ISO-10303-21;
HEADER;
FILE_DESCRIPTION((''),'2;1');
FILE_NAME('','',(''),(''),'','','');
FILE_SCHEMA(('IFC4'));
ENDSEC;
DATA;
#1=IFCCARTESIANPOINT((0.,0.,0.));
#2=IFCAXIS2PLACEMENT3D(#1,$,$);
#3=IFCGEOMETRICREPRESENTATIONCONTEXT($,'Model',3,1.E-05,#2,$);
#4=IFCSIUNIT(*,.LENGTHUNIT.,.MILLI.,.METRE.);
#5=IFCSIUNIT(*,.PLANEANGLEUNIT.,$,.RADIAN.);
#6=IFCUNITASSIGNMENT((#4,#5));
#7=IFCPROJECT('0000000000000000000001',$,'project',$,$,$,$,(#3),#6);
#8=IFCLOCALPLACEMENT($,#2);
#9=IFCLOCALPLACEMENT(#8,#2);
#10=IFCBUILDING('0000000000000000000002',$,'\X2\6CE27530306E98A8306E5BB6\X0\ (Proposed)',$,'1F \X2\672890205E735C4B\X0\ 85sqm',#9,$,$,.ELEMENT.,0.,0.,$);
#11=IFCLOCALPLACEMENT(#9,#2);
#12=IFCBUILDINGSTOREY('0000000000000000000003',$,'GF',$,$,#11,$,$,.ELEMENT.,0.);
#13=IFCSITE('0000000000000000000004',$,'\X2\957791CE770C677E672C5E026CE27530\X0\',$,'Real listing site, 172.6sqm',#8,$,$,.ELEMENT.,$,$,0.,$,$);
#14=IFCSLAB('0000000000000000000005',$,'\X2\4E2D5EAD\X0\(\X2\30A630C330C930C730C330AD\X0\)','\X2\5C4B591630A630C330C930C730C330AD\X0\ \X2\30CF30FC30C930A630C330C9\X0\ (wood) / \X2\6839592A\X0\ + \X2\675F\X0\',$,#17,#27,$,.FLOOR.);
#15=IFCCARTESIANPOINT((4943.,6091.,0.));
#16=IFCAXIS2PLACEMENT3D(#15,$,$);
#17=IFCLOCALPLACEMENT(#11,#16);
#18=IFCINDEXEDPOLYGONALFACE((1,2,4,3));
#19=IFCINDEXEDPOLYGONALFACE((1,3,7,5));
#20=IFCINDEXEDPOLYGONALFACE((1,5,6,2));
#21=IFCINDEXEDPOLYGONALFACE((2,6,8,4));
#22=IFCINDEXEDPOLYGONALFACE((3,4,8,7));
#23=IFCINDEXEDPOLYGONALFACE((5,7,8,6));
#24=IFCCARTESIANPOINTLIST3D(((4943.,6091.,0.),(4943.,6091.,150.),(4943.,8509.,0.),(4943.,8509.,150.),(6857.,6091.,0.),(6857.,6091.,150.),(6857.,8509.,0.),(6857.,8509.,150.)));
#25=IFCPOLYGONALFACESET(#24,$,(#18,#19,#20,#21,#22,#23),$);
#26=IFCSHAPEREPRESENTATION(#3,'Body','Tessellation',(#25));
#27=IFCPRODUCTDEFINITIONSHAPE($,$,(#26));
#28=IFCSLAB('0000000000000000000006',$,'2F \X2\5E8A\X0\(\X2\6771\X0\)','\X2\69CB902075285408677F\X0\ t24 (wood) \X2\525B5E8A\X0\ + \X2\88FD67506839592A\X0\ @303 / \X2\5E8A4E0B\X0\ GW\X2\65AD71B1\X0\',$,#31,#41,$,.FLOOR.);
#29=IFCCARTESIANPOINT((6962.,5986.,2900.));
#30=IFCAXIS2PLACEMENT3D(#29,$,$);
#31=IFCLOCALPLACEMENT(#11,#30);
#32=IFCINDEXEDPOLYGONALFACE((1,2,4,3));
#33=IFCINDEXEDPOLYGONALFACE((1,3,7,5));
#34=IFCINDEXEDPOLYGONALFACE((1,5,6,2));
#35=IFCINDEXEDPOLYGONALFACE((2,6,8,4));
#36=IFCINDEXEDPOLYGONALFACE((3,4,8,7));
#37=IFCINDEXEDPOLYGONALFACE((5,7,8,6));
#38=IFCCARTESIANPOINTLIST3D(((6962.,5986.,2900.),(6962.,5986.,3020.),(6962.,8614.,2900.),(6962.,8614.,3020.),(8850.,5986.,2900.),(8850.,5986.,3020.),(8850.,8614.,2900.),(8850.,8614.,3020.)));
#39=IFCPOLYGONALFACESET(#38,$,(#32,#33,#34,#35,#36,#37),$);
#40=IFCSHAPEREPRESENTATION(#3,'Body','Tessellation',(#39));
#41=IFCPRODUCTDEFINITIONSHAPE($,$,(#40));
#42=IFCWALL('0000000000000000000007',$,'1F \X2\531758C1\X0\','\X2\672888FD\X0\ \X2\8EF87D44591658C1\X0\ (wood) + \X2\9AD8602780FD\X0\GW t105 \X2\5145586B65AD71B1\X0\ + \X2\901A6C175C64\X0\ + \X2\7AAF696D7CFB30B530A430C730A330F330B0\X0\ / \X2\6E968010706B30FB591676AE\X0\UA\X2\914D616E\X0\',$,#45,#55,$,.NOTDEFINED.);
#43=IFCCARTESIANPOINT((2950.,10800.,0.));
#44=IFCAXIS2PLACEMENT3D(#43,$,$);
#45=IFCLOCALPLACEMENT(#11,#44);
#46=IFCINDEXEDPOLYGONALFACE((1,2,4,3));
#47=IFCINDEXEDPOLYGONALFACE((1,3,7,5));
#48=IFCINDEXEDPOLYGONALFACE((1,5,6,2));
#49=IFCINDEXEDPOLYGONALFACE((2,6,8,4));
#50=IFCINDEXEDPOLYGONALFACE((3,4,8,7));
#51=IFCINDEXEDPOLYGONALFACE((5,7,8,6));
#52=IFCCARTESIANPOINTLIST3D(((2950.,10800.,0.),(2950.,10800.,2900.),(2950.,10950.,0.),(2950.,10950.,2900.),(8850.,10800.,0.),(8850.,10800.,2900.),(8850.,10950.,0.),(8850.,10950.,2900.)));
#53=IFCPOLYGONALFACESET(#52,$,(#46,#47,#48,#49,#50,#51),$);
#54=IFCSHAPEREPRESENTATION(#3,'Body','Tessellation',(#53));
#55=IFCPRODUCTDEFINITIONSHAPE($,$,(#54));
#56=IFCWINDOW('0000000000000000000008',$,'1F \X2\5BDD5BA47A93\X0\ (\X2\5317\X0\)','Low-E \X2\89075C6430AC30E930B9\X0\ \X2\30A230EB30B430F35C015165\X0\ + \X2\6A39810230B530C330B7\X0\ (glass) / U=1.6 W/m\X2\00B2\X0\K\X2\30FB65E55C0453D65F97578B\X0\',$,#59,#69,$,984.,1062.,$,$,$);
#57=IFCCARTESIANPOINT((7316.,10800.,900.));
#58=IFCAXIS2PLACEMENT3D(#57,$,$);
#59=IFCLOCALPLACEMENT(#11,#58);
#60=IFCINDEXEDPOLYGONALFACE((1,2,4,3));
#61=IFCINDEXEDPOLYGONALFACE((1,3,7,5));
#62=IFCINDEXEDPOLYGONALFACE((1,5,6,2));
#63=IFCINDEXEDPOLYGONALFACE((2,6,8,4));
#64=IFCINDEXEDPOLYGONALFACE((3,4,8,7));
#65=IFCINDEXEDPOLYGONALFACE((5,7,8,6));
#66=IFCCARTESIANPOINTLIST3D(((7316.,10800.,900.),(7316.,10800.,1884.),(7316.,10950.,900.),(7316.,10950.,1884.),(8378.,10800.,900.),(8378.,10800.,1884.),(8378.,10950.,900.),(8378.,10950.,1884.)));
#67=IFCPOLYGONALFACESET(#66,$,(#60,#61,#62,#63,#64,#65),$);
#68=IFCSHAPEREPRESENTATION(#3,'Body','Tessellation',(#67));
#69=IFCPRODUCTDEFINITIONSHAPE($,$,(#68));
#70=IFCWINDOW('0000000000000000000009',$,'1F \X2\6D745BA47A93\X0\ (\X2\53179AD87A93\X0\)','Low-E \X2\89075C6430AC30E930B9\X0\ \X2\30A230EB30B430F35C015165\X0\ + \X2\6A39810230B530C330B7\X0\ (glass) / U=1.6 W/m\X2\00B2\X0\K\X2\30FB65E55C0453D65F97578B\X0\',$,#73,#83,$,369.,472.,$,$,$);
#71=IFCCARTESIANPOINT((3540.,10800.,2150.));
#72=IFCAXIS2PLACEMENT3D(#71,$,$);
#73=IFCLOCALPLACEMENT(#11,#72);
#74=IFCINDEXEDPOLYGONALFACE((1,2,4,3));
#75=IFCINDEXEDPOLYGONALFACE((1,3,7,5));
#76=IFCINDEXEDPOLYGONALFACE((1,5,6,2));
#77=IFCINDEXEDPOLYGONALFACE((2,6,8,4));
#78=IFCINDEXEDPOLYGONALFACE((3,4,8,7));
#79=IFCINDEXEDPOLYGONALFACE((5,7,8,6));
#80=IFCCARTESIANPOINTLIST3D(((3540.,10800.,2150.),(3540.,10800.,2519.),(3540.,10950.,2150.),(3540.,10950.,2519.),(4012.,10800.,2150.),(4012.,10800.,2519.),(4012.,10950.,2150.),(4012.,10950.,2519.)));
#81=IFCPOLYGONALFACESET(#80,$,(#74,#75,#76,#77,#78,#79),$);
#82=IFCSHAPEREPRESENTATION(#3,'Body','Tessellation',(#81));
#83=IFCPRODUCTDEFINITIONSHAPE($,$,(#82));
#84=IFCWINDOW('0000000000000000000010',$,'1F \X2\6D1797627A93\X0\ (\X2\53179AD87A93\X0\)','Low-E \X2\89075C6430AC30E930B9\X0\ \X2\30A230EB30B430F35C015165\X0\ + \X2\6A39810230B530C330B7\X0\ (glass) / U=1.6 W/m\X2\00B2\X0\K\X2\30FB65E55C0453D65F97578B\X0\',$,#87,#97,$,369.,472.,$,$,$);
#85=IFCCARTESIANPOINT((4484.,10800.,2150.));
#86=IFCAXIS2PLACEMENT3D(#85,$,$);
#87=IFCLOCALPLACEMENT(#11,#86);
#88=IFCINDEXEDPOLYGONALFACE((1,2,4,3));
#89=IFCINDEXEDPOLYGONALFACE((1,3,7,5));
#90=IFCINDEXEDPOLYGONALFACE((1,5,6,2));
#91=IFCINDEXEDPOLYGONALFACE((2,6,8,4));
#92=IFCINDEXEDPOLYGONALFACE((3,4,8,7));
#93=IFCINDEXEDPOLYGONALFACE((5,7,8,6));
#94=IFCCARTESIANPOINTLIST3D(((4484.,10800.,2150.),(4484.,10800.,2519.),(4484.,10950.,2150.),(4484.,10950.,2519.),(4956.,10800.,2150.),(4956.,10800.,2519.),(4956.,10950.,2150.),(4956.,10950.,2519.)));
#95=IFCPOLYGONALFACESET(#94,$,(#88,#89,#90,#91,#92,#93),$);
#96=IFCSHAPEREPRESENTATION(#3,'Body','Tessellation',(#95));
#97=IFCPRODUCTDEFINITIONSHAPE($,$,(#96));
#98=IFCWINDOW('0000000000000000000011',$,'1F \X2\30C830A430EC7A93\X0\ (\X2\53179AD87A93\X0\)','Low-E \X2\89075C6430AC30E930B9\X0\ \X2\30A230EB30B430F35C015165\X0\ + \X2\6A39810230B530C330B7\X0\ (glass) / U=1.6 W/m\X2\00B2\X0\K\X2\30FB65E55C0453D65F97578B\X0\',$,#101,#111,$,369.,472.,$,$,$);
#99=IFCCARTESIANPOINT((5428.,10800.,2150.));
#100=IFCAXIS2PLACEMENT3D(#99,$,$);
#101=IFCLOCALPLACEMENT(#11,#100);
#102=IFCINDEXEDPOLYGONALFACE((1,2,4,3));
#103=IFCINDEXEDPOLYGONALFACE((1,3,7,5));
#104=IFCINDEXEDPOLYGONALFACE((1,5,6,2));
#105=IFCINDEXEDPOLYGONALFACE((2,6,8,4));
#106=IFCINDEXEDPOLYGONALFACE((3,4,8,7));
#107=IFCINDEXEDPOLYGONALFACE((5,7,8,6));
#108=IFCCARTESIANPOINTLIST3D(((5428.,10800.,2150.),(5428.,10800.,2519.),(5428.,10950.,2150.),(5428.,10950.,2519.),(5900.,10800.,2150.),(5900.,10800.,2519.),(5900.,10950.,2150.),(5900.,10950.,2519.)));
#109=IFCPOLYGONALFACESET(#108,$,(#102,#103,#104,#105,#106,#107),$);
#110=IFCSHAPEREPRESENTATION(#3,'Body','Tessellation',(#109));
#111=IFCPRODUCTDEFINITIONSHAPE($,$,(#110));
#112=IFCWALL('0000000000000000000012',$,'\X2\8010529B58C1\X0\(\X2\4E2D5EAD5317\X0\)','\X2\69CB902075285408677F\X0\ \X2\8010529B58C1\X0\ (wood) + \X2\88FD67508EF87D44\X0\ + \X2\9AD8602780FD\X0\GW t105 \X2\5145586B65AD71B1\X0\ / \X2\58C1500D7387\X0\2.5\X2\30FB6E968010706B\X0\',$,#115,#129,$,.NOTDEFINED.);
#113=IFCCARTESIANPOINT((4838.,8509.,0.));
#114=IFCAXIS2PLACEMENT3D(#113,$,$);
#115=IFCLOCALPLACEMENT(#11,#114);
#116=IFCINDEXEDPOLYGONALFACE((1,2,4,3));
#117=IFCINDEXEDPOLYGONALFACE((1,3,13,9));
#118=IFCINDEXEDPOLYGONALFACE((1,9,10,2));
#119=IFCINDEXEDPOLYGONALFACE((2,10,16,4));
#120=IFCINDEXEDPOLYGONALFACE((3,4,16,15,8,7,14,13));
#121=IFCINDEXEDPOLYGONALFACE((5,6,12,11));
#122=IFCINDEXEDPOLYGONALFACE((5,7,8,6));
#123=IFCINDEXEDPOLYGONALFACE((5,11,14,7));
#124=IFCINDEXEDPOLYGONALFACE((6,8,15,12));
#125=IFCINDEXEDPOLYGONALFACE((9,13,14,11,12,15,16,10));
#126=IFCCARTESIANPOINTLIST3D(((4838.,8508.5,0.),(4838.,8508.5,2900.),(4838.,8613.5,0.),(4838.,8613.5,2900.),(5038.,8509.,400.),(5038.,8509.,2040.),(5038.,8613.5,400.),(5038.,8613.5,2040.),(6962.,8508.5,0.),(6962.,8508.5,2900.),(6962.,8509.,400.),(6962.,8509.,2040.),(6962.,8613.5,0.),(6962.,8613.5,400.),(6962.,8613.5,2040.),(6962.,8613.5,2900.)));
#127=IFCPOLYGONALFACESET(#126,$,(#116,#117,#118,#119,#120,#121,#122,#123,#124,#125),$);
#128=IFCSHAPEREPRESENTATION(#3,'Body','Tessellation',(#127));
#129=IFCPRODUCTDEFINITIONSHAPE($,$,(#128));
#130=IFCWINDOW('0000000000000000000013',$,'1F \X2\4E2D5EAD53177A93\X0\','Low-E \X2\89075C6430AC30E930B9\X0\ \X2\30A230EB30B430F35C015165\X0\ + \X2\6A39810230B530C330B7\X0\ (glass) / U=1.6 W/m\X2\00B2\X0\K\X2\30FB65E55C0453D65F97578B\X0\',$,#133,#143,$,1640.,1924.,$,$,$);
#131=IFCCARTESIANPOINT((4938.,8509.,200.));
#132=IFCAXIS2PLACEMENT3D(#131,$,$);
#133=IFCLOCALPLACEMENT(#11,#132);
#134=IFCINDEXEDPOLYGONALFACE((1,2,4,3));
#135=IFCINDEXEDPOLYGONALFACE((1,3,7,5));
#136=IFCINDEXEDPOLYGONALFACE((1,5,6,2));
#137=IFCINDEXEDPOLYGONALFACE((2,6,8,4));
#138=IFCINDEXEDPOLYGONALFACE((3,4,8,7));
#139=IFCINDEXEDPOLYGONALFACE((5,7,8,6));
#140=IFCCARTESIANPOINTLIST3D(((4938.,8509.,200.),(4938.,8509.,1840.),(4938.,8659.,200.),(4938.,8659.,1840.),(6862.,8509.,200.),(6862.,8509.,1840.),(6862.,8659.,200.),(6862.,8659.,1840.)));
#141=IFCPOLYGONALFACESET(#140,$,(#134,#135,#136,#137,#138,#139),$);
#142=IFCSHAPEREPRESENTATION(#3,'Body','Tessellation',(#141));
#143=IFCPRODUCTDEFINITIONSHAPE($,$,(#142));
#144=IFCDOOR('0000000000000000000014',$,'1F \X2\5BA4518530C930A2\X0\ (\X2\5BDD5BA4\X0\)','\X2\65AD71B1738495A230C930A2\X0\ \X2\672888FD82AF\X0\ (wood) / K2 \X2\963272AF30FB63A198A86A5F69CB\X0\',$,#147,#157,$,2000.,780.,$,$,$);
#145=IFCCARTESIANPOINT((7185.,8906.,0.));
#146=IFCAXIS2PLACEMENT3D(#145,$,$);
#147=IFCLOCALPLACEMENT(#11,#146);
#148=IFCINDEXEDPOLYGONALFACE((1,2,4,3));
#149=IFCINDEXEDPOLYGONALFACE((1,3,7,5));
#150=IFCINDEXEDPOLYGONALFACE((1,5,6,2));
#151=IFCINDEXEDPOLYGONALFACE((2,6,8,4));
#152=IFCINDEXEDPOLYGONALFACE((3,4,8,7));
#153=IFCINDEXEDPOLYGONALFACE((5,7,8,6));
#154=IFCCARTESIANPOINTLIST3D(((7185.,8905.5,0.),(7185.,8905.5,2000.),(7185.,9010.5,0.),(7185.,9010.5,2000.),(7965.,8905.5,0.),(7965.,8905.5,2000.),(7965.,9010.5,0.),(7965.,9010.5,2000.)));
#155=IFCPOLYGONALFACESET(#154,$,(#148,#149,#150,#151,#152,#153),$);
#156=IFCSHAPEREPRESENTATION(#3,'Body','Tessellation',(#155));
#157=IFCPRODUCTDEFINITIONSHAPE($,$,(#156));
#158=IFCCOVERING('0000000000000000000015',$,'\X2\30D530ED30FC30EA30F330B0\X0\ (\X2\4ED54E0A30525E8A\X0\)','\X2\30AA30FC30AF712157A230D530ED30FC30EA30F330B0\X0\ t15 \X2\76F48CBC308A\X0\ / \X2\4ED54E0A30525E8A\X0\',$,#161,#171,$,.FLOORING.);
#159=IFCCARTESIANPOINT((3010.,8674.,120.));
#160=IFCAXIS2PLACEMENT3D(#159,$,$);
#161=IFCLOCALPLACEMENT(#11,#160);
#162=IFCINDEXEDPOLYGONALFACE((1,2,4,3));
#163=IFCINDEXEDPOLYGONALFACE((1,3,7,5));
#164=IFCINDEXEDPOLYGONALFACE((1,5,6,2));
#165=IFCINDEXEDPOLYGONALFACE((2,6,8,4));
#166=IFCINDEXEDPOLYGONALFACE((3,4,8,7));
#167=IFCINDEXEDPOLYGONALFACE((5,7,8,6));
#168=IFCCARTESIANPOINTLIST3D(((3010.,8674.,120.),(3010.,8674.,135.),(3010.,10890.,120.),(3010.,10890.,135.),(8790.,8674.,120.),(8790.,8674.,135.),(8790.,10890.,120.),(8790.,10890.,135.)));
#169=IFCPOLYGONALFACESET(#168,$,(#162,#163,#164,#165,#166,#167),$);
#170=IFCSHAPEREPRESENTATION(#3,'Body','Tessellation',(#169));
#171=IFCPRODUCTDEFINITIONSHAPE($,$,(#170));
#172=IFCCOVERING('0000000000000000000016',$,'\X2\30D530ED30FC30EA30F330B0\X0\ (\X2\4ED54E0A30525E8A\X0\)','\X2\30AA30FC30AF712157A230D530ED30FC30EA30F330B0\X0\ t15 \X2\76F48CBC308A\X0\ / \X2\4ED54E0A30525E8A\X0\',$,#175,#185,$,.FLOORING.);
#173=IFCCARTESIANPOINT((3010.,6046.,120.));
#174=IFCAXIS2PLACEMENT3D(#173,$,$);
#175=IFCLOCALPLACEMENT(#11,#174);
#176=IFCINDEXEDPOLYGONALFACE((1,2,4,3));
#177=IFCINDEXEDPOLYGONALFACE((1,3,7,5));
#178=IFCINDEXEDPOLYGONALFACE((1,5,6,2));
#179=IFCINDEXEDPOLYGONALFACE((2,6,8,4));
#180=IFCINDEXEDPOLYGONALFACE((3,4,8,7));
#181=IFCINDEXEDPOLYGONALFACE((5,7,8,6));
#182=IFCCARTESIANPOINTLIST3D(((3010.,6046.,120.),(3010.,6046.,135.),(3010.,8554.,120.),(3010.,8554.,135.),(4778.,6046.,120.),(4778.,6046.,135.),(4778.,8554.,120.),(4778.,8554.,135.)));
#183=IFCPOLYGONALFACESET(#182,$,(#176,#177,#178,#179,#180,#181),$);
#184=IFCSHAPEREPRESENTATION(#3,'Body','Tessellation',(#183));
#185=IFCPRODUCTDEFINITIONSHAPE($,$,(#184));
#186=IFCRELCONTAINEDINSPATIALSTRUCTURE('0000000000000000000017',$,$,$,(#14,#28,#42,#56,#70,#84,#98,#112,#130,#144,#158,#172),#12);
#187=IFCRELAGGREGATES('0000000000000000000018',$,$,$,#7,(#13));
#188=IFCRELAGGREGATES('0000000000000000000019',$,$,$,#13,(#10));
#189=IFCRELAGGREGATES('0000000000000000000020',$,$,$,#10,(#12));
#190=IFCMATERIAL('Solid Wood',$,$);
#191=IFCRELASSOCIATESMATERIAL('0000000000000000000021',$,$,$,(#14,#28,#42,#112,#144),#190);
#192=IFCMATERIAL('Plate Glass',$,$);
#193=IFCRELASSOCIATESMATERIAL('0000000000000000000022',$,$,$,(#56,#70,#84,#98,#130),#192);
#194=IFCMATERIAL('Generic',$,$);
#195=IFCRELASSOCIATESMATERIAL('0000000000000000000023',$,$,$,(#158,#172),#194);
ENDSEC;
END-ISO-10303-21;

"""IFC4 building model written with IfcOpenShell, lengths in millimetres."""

from ifc_helpers import new_model, si_unit, frame, frame_2d, origin, place, context, project, spatial, rectangle, extrude, material, element, fill, save


model = new_model("IFC4")

# Units and contexts
model_context = context("Model", 3, precision=1e-05, world=origin())
ifc_project = project(units=[si_unit("LENGTHUNIT", "METRE", prefix="MILLI"), si_unit("PLANEANGLEUNIT", "RADIAN")], contexts=[model_context])

# Site, building, storey
site_placement = place(None, origin())
site = spatial("IfcSite", under=ifc_project, at=site_placement, Name="長野県松本市波田", ObjectType="Real listing site, 172.6sqm", CompositionType="ELEMENT", RefElevation=0.0)
building_placement = place(site_placement, origin())
building = spatial("IfcBuilding", under=site, at=building_placement, Name="波田の風の家 (Proposed)", ObjectType="1F 木造平屋 85sqm", CompositionType="ELEMENT", ElevationOfRefHeight=0.0, ElevationOfTerrain=0.0)
storey_placement = place(building_placement, origin())
storey = spatial("IfcBuildingStorey", under=building, at=storey_placement, Name="GF", CompositionType="ELEMENT", Elevation=0.0)

# Slabs
ifc_material_1 = material(Name="Solid Wood")
slab_1_placement = place(storey_placement, frame((4943.0, 6091.0, 0.0)))
element("IfcSlab", 1, at=slab_1_placement, inside=storey, material=ifc_material_1, Name="中庭(ウッドデッキ)", Description="屋外ウッドデッキ ハードウッド (wood) / 根太 + 束", PredefinedType="FLOOR", context=model_context, shape_type="SweptSolid", body=[
    extrude(rectangle(XDim=1914.0, YDim=2418.0, at=frame_2d((957.0, 1209.0))), frame((4943.0, 6091.0, 0.0)), (0.0, 0.0, 1.0), 150.0),
])
slab_2_placement = place(storey_placement, frame((6962.0, 5986.0, 2900.0)))
element("IfcSlab", 2, at=slab_2_placement, inside=storey, material=ifc_material_1, Name="2F 床(東)", Description="構造用合板 t24 (wood) 剛床 + 製材根太 @303 / 床下 GW断熱", PredefinedType="FLOOR", context=model_context, shape_type="SweptSolid", body=[
    extrude(rectangle(XDim=1888.0, YDim=2628.0, at=frame_2d((944.0, 1314.0))), frame((6962.0, 5986.0, 2900.0)), (0.0, 0.0, 1.0), 120.0),
])

# Wall, openings, windows
wall_1_placement = place(storey_placement, frame((2950.0, 10800.0, 0.0)))
wall_1 = element("IfcWall", 3, at=wall_1_placement, inside=storey, material=ifc_material_1, Name="1F 北壁", Description="木製 軸組外壁 (wood) + 高性能GW t105 充填断熱 + 通気層 + 窯業系サイディング / 準耐火・外皮UA配慮", PredefinedType="NOTDEFINED", context=model_context, shape_type="SweptSolid", body=[
    extrude(rectangle(XDim=5900.0, YDim=150.0, at=frame_2d((2950.0, 75.0))), frame((2950.0, 10800.0, 0.0)), (0.0, 0.0, 1.0), 2900.0),
])
opening_1_placement = place(storey_placement, frame((7316.0, 10800.0, 900.0)))
opening_1 = element("IfcOpeningElement", 4, at=opening_1_placement, cuts=wall_1, PredefinedType="NOTDEFINED", context=model_context, shape_type="SweptSolid", body=[
    extrude(rectangle(XDim=1062.0, YDim=150.0, at=frame_2d((531.0, 75.0))), frame((7316.0, 10800.0, 900.0)), (0.0, 0.0, 1.0), 984.0),
])
opening_2_placement = place(storey_placement, frame((3540.0, 10800.0, 2150.0)))
opening_2 = element("IfcOpeningElement", 5, at=opening_2_placement, cuts=wall_1, PredefinedType="NOTDEFINED", context=model_context, shape_type="SweptSolid", body=[
    extrude(rectangle(XDim=472.0, YDim=150.0, at=frame_2d((236.0, 75.0))), frame((3540.0, 10800.0, 2150.0)), (0.0, 0.0, 1.0), 369.0),
])
opening_3_placement = place(storey_placement, frame((4484.0, 10800.0, 2150.0)))
opening_3 = element("IfcOpeningElement", 6, at=opening_3_placement, cuts=wall_1, PredefinedType="NOTDEFINED", context=model_context, shape_type="SweptSolid", body=[
    extrude(rectangle(XDim=472.0, YDim=150.0, at=frame_2d((236.0, 75.0))), frame((4484.0, 10800.0, 2150.0)), (0.0, 0.0, 1.0), 369.0),
])
opening_4_placement = place(storey_placement, frame((5428.0, 10800.0, 2150.0)))
opening_4 = element("IfcOpeningElement", 7, at=opening_4_placement, cuts=wall_1, PredefinedType="NOTDEFINED", context=model_context, shape_type="SweptSolid", body=[
    extrude(rectangle(XDim=472.0, YDim=150.0, at=frame_2d((236.0, 75.0))), frame((5428.0, 10800.0, 2150.0)), (0.0, 0.0, 1.0), 369.0),
])
ifc_material_2 = material(Name="Plate Glass")
window_1_placement = place(storey_placement, frame((7316.0, 10800.0, 900.0)))
window_1 = element("IfcWindow", 8, at=window_1_placement, inside=storey, material=ifc_material_2, Name="1F 寝室窓 (北)", Description="Low-E 複層ガラス アルゴン封入 + 樹脂サッシ (glass) / U=1.6 W/m²K・日射取得型", OverallHeight=984.0, OverallWidth=1062.0, context=model_context, shape_type="SweptSolid", body=[
    extrude(rectangle(XDim=1062.0, YDim=150.0, at=frame_2d((531.0, 75.0))), frame((7316.0, 10800.0, 900.0)), (0.0, 0.0, 1.0), 984.0),
])
fill(opening_1, window_1)
window_2_placement = place(storey_placement, frame((3540.0, 10800.0, 2150.0)))
window_2 = element("IfcWindow", 9, at=window_2_placement, inside=storey, material=ifc_material_2, Name="1F 浴室窓 (北高窓)", Description="Low-E 複層ガラス アルゴン封入 + 樹脂サッシ (glass) / U=1.6 W/m²K・日射取得型", OverallHeight=369.0, OverallWidth=472.0, context=model_context, shape_type="SweptSolid", body=[
    extrude(rectangle(XDim=472.0, YDim=150.0, at=frame_2d((236.0, 75.0))), frame((3540.0, 10800.0, 2150.0)), (0.0, 0.0, 1.0), 369.0),
])
fill(opening_2, window_2)
window_3_placement = place(storey_placement, frame((4484.0, 10800.0, 2150.0)))
window_3 = element("IfcWindow", 10, at=window_3_placement, inside=storey, material=ifc_material_2, Name="1F 洗面窓 (北高窓)", Description="Low-E 複層ガラス アルゴン封入 + 樹脂サッシ (glass) / U=1.6 W/m²K・日射取得型", OverallHeight=369.0, OverallWidth=472.0, context=model_context, shape_type="SweptSolid", body=[
    extrude(rectangle(XDim=472.0, YDim=150.0, at=frame_2d((236.0, 75.0))), frame((4484.0, 10800.0, 2150.0)), (0.0, 0.0, 1.0), 369.0),
])
fill(opening_3, window_3)
window_4_placement = place(storey_placement, frame((5428.0, 10800.0, 2150.0)))
window_4 = element("IfcWindow", 11, at=window_4_placement, inside=storey, material=ifc_material_2, Name="1F トイレ窓 (北高窓)", Description="Low-E 複層ガラス アルゴン封入 + 樹脂サッシ (glass) / U=1.6 W/m²K・日射取得型", OverallHeight=369.0, OverallWidth=472.0, context=model_context, shape_type="SweptSolid", body=[
    extrude(rectangle(XDim=472.0, YDim=150.0, at=frame_2d((236.0, 75.0))), frame((5428.0, 10800.0, 2150.0)), (0.0, 0.0, 1.0), 369.0),
])
fill(opening_4, window_4)

# Wall, opening, window
wall_2_placement = place(storey_placement, frame((4838.0, 8509.0, 0.0)))
wall_2 = element("IfcWall", 12, at=wall_2_placement, inside=storey, material=ifc_material_1, Name="耐力壁(中庭北)", Description="構造用合板 耐力壁 (wood) + 製材軸組 + 高性能GW t105 充填断熱 / 壁倍率2.5・準耐火", PredefinedType="NOTDEFINED", context=model_context, shape_type="SweptSolid", body=[
    extrude(rectangle(XDim=2124.0, YDim=105.0, at=frame_2d((1062.0, 52.0))), frame((4838.0, 8509.0, 0.0)), (0.0, 0.0, 1.0), 2900.0),
])
opening_5_placement = place(storey_placement, frame((4938.0, 8509.0, 200.0)))
opening_5 = element("IfcOpeningElement", 13, at=opening_5_placement, cuts=wall_2, PredefinedType="NOTDEFINED", context=model_context, shape_type="SweptSolid", body=[
    extrude(rectangle(XDim=1924.0, YDim=150.0, at=frame_2d((962.0, 75.0))), frame((4938.0, 8509.0, 200.0)), (0.0, 0.0, 1.0), 1640.0),
])
window_5_placement = place(storey_placement, frame((4938.0, 8509.0, 200.0)))
window_5 = element("IfcWindow", 14, at=window_5_placement, inside=storey, material=ifc_material_2, Name="1F 中庭北窓", Description="Low-E 複層ガラス アルゴン封入 + 樹脂サッシ (glass) / U=1.6 W/m²K・日射取得型", OverallHeight=1640.0, OverallWidth=1924.0, context=model_context, shape_type="SweptSolid", body=[
    extrude(rectangle(XDim=1924.0, YDim=150.0, at=frame_2d((962.0, 75.0))), frame((4938.0, 8509.0, 200.0)), (0.0, 0.0, 1.0), 1640.0),
])
fill(opening_5, window_5)

# Door
door_1_placement = place(storey_placement, frame((7185.0, 8906.0, 0.0)))
element("IfcDoor", 15, at=door_1_placement, inside=storey, material=ifc_material_1, Name="1F 室内ドア (寝室)", Description="断熱玄関ドア 木製芯 (wood) / K2 防犯・採風機構", OverallHeight=2000.0, OverallWidth=780.0, context=model_context, shape_type="SweptSolid", body=[
    extrude(rectangle(XDim=780.0, YDim=105.0, at=frame_2d((390.0, 52.0))), frame((7185.0, 8906.0, 0.0)), (0.0, 0.0, 1.0), 2000.0),
])

# Coverings
ifc_material_3 = material(Name="Generic")
covering_1_placement = place(storey_placement, frame((3010.0, 8674.0, 120.0)))
element("IfcCovering", 16, at=covering_1_placement, inside=storey, material=ifc_material_3, Name="フローリング (仕上げ床)", Description="オーク無垢フローリング t15 直貼り / 仕上げ床", PredefinedType="FLOORING", context=model_context, shape_type="SweptSolid", body=[
    extrude(rectangle(XDim=5780.0, YDim=2216.0, at=frame_2d((2890.0, 1108.0))), frame((3010.0, 8674.0, 120.0)), (0.0, 0.0, 1.0), 15.0),
])
covering_2_placement = place(storey_placement, frame((3010.0, 6046.0, 120.0)))
element("IfcCovering", 17, at=covering_2_placement, inside=storey, material=ifc_material_3, Name="フローリング (仕上げ床)", Description="オーク無垢フローリング t15 直貼り / 仕上げ床", PredefinedType="FLOORING", context=model_context, shape_type="SweptSolid", body=[
    extrude(rectangle(XDim=1768.0, YDim=2508.0, at=frame_2d((884.0, 1254.0))), frame((3010.0, 6046.0, 120.0)), (0.0, 0.0, 1.0), 15.0),
])

save(model, "model.ifc")
